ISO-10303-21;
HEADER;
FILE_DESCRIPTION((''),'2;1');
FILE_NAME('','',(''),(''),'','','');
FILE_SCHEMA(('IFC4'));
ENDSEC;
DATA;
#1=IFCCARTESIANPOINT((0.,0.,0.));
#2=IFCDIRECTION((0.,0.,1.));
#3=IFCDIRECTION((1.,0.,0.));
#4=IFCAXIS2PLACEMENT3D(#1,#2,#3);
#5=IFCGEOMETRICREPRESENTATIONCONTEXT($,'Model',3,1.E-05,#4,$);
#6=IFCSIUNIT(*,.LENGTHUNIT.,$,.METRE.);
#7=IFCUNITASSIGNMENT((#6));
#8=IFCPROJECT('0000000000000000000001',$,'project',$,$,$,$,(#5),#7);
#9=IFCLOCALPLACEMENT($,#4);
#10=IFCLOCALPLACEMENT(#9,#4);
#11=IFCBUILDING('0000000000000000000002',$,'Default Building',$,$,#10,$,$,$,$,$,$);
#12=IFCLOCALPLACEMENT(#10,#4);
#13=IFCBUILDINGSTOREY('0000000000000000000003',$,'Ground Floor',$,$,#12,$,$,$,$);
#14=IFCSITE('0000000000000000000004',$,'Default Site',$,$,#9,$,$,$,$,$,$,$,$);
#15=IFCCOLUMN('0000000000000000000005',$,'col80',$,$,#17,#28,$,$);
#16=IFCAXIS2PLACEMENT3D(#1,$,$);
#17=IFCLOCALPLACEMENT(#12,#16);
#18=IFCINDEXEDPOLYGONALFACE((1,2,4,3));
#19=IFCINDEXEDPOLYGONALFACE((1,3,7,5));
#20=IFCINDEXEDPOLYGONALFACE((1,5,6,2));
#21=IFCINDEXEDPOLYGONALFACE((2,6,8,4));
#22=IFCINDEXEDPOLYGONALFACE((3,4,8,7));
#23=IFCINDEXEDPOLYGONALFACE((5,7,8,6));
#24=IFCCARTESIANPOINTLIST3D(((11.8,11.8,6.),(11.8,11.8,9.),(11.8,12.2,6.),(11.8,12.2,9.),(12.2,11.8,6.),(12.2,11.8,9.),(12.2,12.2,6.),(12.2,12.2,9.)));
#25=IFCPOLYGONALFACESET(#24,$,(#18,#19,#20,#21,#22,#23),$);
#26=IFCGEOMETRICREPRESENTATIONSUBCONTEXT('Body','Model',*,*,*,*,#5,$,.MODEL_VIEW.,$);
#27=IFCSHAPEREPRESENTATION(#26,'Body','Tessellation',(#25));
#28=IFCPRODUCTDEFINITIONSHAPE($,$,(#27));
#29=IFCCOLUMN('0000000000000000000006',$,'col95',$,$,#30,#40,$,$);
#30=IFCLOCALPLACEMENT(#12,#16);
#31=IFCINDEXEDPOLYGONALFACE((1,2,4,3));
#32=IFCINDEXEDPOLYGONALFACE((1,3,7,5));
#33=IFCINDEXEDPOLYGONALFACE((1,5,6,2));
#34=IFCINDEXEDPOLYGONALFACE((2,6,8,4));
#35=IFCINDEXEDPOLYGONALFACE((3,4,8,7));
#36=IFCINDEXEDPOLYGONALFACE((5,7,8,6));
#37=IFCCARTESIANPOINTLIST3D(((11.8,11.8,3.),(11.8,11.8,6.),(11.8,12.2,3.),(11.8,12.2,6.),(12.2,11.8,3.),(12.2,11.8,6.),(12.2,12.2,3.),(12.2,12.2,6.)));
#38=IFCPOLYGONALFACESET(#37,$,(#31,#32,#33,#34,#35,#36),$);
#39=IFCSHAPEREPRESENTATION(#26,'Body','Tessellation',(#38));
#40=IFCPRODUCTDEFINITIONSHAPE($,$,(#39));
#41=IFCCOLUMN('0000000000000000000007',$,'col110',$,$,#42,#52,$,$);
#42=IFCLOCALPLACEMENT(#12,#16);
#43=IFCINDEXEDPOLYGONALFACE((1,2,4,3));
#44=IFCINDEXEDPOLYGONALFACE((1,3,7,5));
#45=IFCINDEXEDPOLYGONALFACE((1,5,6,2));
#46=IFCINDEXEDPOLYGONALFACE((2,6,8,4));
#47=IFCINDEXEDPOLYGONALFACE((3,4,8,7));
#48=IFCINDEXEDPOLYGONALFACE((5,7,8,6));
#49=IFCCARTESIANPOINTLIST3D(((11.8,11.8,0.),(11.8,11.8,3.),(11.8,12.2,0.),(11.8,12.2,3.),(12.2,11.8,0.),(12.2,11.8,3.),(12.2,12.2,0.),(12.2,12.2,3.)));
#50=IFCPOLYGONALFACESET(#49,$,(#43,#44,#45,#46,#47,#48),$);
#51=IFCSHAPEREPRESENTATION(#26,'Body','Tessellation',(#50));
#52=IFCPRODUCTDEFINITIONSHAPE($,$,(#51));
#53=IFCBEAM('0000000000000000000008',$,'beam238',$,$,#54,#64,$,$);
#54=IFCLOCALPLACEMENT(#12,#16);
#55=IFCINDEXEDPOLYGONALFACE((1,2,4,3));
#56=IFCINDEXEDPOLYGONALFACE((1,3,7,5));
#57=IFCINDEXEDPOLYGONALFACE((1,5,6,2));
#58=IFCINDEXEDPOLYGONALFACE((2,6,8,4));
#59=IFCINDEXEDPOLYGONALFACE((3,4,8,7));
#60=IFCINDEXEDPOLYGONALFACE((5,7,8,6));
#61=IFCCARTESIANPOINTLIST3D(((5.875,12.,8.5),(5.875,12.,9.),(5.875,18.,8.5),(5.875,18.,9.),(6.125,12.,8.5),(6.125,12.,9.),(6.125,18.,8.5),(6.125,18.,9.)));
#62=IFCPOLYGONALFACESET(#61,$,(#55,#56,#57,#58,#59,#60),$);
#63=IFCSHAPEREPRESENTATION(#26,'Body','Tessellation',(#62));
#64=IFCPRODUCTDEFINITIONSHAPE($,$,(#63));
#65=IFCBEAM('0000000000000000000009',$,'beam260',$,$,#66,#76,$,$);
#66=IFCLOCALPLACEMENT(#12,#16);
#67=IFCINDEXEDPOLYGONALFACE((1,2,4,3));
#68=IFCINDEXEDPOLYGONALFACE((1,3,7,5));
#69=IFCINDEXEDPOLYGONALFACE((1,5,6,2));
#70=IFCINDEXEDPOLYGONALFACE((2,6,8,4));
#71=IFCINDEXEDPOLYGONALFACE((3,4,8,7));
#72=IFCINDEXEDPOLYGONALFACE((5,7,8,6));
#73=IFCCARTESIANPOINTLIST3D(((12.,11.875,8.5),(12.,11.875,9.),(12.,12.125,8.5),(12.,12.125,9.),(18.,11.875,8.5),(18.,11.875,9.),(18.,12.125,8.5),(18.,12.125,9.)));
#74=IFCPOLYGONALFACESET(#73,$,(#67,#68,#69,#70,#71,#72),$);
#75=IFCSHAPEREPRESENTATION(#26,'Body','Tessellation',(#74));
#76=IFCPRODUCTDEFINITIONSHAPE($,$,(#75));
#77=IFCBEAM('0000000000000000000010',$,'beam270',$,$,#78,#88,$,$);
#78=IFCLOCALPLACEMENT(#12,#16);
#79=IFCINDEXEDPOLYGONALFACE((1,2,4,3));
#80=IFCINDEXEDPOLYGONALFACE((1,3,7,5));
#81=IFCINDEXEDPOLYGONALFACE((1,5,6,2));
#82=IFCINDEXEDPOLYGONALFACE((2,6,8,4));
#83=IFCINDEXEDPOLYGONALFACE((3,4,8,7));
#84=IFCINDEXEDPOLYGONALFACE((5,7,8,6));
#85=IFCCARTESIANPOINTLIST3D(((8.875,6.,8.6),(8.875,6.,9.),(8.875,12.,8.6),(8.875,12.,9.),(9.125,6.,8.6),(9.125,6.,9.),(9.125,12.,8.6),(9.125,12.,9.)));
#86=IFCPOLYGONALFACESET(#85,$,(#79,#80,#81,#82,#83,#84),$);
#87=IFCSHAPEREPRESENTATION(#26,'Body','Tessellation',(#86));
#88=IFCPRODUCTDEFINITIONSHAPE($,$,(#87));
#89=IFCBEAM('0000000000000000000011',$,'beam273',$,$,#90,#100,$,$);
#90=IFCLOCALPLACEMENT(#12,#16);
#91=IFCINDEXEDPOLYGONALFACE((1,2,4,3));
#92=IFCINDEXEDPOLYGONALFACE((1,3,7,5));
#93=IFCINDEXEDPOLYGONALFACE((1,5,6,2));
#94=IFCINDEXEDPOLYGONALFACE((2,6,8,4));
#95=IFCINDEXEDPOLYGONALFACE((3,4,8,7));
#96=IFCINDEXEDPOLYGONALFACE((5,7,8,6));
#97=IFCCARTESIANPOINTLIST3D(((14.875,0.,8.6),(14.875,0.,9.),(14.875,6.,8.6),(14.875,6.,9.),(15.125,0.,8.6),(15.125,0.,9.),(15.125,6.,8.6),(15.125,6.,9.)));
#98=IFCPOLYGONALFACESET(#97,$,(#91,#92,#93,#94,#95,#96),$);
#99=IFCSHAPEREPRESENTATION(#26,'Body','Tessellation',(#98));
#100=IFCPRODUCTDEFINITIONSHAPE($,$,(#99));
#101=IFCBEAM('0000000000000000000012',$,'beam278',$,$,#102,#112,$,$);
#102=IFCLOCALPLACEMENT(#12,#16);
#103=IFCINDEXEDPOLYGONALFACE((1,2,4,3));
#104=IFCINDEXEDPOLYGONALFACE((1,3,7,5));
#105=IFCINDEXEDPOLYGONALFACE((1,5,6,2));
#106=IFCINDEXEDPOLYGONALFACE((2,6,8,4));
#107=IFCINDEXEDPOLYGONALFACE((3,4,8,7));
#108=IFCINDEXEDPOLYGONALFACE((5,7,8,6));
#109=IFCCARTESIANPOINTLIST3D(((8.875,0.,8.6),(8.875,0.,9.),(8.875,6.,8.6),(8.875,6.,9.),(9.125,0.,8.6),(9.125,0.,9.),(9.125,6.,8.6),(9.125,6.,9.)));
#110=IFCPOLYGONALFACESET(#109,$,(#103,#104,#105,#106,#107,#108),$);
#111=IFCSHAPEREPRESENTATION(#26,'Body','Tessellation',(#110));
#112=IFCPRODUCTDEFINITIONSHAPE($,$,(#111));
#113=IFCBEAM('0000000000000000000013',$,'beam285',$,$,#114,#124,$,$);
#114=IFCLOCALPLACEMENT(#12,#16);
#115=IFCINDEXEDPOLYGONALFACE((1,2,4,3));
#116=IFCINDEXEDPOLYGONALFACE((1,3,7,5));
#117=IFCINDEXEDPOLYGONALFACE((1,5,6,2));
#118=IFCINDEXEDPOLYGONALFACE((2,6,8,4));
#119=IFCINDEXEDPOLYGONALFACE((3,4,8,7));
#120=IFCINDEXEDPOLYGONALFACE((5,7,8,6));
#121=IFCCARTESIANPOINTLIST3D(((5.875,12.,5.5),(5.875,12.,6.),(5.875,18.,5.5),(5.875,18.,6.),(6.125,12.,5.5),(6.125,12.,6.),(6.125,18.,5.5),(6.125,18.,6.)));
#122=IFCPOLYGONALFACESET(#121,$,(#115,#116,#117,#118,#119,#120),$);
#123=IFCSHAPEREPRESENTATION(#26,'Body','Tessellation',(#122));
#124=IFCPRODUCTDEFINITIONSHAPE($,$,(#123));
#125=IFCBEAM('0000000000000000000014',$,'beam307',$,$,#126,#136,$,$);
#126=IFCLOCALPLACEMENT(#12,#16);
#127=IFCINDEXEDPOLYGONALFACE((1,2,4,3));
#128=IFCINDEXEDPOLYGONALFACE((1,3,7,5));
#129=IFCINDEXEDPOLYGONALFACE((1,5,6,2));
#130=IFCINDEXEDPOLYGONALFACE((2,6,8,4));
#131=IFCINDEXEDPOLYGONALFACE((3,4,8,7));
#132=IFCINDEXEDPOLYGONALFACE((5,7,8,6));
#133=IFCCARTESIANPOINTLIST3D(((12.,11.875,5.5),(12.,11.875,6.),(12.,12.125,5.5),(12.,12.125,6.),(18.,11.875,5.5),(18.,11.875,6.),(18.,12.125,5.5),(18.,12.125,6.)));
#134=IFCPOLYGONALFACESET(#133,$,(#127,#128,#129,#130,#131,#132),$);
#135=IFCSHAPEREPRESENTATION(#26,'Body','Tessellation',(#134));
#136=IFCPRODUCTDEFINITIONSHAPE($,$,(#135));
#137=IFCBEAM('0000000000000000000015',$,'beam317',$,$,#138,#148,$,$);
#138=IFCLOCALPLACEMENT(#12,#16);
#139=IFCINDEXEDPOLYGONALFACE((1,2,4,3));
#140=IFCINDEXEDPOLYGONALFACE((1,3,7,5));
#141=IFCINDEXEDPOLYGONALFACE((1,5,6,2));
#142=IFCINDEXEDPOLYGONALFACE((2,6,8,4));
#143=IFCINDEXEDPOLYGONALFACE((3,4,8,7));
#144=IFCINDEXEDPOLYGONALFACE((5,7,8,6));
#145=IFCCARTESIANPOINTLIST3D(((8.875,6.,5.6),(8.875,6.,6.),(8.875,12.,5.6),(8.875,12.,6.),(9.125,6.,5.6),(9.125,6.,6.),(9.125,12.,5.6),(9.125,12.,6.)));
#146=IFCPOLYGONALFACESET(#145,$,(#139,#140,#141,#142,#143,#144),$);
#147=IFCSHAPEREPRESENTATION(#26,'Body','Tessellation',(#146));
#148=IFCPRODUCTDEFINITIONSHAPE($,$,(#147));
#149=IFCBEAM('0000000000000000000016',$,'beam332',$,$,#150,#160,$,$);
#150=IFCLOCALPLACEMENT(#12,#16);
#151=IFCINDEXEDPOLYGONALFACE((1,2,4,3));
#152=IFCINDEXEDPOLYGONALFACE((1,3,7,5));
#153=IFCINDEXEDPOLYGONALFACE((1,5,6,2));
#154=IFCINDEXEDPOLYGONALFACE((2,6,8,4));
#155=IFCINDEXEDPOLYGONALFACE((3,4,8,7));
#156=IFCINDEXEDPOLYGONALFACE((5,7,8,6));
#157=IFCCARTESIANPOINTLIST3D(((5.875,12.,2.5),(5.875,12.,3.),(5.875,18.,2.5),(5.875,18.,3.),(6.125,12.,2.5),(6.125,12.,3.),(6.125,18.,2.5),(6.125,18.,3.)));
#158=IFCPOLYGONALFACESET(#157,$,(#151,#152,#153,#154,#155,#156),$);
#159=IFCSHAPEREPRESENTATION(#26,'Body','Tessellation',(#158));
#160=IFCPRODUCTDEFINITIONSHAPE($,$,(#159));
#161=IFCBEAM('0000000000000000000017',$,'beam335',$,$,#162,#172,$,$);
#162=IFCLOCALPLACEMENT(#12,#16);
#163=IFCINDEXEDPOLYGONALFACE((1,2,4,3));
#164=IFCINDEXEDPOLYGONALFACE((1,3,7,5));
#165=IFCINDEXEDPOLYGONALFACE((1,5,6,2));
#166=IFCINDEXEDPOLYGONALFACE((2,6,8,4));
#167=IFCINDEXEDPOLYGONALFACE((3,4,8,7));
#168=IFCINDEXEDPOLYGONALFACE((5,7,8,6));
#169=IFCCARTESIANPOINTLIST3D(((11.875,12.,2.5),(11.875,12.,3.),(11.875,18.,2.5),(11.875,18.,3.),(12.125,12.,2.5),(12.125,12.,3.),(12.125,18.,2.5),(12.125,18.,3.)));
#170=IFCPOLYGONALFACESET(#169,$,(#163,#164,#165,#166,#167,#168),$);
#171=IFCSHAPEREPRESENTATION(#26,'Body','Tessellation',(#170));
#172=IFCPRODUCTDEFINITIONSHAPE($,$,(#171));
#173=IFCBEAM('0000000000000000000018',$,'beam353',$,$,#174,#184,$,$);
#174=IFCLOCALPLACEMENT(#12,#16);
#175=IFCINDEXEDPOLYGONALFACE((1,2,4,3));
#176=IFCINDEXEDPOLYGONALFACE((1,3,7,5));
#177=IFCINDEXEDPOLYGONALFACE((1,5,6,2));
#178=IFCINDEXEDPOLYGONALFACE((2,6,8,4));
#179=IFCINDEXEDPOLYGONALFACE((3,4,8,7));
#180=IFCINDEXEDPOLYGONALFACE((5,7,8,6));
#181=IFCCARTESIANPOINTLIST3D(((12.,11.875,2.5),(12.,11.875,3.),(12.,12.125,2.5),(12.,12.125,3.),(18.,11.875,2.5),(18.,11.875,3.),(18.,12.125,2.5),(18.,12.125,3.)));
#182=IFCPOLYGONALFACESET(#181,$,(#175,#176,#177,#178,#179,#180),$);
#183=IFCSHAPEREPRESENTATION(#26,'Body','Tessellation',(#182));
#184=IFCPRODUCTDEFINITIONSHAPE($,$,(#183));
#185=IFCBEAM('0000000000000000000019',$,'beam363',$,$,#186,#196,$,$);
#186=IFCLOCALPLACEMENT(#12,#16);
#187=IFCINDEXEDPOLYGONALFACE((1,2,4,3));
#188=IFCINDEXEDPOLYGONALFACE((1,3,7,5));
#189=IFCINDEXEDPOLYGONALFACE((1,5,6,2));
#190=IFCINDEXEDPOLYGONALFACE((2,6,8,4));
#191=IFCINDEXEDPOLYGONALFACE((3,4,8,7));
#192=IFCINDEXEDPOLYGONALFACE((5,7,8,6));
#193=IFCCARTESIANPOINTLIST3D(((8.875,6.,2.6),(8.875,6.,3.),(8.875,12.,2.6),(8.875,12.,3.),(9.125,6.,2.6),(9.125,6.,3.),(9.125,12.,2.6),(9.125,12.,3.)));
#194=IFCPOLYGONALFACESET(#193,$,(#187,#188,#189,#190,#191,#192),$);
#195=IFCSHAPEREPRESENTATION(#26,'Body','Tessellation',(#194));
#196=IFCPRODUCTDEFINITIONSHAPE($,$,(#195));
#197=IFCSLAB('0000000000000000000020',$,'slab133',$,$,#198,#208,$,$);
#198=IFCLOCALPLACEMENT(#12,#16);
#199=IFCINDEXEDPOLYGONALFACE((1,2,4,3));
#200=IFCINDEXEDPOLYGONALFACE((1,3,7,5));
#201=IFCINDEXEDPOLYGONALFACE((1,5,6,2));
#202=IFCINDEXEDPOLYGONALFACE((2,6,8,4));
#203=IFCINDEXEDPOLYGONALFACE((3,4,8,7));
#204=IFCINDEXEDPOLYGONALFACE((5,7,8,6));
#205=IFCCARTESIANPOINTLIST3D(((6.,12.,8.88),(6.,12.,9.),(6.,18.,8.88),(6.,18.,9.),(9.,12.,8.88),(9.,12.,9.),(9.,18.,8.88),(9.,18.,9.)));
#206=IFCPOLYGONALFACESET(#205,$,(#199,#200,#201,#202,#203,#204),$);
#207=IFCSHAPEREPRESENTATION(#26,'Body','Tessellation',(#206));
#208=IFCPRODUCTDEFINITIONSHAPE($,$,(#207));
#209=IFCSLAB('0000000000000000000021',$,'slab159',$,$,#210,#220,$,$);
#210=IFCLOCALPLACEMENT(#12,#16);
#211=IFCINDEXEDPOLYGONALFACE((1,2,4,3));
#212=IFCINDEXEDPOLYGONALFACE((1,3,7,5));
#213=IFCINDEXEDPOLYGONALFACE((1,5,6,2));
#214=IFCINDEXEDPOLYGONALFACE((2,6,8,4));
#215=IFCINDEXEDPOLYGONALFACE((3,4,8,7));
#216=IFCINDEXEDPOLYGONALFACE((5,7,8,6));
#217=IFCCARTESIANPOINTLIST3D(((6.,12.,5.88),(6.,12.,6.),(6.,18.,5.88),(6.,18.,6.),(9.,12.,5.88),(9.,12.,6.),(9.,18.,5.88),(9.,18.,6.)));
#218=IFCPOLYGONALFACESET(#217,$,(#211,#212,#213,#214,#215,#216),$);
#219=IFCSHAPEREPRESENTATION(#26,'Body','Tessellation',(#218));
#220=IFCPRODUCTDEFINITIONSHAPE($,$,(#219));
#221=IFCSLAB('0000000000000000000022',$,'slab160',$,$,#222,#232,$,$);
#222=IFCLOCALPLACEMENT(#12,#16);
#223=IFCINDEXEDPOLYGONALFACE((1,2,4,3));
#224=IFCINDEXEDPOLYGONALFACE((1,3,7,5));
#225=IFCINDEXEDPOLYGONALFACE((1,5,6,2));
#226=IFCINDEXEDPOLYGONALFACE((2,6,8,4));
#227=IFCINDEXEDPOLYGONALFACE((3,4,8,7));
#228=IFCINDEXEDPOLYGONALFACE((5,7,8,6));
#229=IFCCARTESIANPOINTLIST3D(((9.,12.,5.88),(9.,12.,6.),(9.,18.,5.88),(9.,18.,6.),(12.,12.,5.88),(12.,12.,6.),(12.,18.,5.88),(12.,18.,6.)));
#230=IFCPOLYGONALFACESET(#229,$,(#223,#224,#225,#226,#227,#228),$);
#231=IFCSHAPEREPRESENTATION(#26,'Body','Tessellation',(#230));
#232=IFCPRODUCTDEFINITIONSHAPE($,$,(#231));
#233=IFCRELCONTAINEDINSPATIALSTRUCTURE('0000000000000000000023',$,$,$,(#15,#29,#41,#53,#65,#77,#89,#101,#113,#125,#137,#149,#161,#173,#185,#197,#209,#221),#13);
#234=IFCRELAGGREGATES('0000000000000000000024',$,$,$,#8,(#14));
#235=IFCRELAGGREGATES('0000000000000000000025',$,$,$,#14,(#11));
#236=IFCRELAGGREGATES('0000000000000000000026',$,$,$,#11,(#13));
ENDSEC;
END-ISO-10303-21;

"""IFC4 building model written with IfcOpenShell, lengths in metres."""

from ifc_helpers import new_model, si_unit, frame, origin_with_axes, place, context, subcontext, project, spatial, indexed_curve, outline, extrude, element, save


model = new_model("IFC4")

# Units and contexts
model_context = context("Model", 3, precision=1e-05, world=origin_with_axes())
body_context = subcontext(model_context, "Body", "Model", "MODEL_VIEW")
ifc_project = project(units=[si_unit("LENGTHUNIT", "METRE")], contexts=[model_context])

# Site, building, storey
site_placement = place(None, origin_with_axes())
site = spatial("IfcSite", under=ifc_project, at=site_placement, Name="Default Site")
building_placement = place(site_placement, origin_with_axes())
building = spatial("IfcBuilding", under=site, at=building_placement, Name="Default Building")
storey_placement = place(building_placement, origin_with_axes())
storey = spatial("IfcBuildingStorey", under=building, at=storey_placement, Name="Ground Floor")

# Columns
for number, where, z_axis, x_axis, name in (
    (1, (11.8, 11.8, 6.0), (0.0, 0.0, 1.0), (1.0, 0.0, 0.0), "col80"),
    (2, (11.8, 11.8, 3.0), (0.0, 0.0, 1.0), (1.0, 0.0, 0.0), "col95"),
    (3, (11.8, 11.8, 0.0), (0.0, 0.0, 1.0), (1.0, 0.0, 0.0), "col110"),
):
    element("IfcColumn", number, at=place(storey_placement, frame(where, z_axis=z_axis, x_axis=x_axis)), inside=storey, Name=name, context=body_context, shape_type="SweptSolid", body=[
        extrude(outline(indexed_curve([(0.0, 0.0), (0.0, 0.4), (0.4, 0.4), (0.4, 0.0), (0.0, 0.0)], self_intersect=False)), origin_with_axes(), (0.0, 0.0, 1.0), 3.0),
    ])

# Beams
for number, where, z_axis, x_axis, name in (
    (4, (6.125, 12.0, 8.5), (0.0, 0.0, 1.0), (0.0, 1.0, 0.0), "beam238"),
    (5, (12.0, 11.875, 8.5), (0.0, 0.0, 1.0), (1.0, 0.0, 0.0), "beam260"),
):
    element("IfcBeam", number, at=place(storey_placement, frame(where, z_axis=z_axis, x_axis=x_axis)), inside=storey, Name=name, context=body_context, shape_type="SweptSolid", body=[
        extrude(outline(indexed_curve([(0.0, 0.0), (0.0, 0.25), (6.0, 0.25), (6.0, 0.0), (0.0, 0.0)], self_intersect=False)), origin_with_axes(), (0.0, 0.0, 1.0), 0.5),
    ])
for number, where, z_axis, x_axis, name in (
    (6, (8.875, 12.0, 8.6), (0.0, 0.0, 1.0), (0.0, -1.0, 0.0), "beam270"),
    (7, (14.875, 6.0, 8.6), (0.0, 0.0, 1.0), (0.0, -1.0, 0.0), "beam273"),
    (8, (8.875, 6.0, 8.6), (0.0, 0.0, 1.0), (0.0, -1.0, 0.0), "beam278"),
):
    element("IfcBeam", number, at=place(storey_placement, frame(where, z_axis=z_axis, x_axis=x_axis)), inside=storey, Name=name, context=body_context, shape_type="SweptSolid", body=[
        extrude(outline(indexed_curve([(0.0, 0.0), (0.0, 0.25), (6.0, 0.25), (6.0, 0.0), (0.0, 0.0)], self_intersect=False)), origin_with_axes(), (0.0, 0.0, 1.0), 0.4),
    ])
for number, where, z_axis, x_axis, name in (
    (9, (6.125, 12.0, 5.5), (0.0, 0.0, 1.0), (0.0, 1.0, 0.0), "beam285"),
    (10, (12.0, 11.875, 5.5), (0.0, 0.0, 1.0), (1.0, 0.0, 0.0), "beam307"),
):
    element("IfcBeam", number, at=place(storey_placement, frame(where, z_axis=z_axis, x_axis=x_axis)), inside=storey, Name=name, context=body_context, shape_type="SweptSolid", body=[
        extrude(outline(indexed_curve([(0.0, 0.0), (0.0, 0.25), (6.0, 0.25), (6.0, 0.0), (0.0, 0.0)], self_intersect=False)), origin_with_axes(), (0.0, 0.0, 1.0), 0.5),
    ])
beam_1_placement = place(storey_placement, frame((8.875, 12.0, 5.6), z_axis=(0.0, 0.0, 1.0), x_axis=(0.0, -1.0, 0.0)))
element("IfcBeam", 11, at=beam_1_placement, inside=storey, Name="beam317", context=body_context, shape_type="SweptSolid", body=[
    extrude(outline(indexed_curve([(0.0, 0.0), (0.0, 0.25), (6.0, 0.25), (6.0, 0.0), (0.0, 0.0)], self_intersect=False)), origin_with_axes(), (0.0, 0.0, 1.0), 0.4),
])
for number, where, z_axis, x_axis, name in (
    (12, (6.125, 12.0, 2.5), (0.0, 0.0, 1.0), (0.0, 1.0, 0.0), "beam332"),
    (13, (12.125, 12.0, 2.5), (0.0, 0.0, 1.0), (0.0, 1.0, 0.0), "beam335"),
    (14, (12.0, 11.875, 2.5), (0.0, 0.0, 1.0), (1.0, 0.0, 0.0), "beam353"),
):
    element("IfcBeam", number, at=place(storey_placement, frame(where, z_axis=z_axis, x_axis=x_axis)), inside=storey, Name=name, context=body_context, shape_type="SweptSolid", body=[
        extrude(outline(indexed_curve([(0.0, 0.0), (0.0, 0.25), (6.0, 0.25), (6.0, 0.0), (0.0, 0.0)], self_intersect=False)), origin_with_axes(), (0.0, 0.0, 1.0), 0.5),
    ])
beam_2_placement = place(storey_placement, frame((8.875, 12.0, 2.6), z_axis=(0.0, 0.0, 1.0), x_axis=(0.0, -1.0, 0.0)))
element("IfcBeam", 15, at=beam_2_placement, inside=storey, Name="beam363", context=body_context, shape_type="SweptSolid", body=[
    extrude(outline(indexed_curve([(0.0, 0.0), (0.0, 0.25), (6.0, 0.25), (6.0, 0.0), (0.0, 0.0)], self_intersect=False)), origin_with_axes(), (0.0, 0.0, 1.0), 0.4),
])

# Slabs
for number, where, z_axis, x_axis, name in (
    (16, (6.0, 12.0, 8.88), (0.0, 0.0, 1.0), (1.0, 0.0, 0.0), "slab133"),
    (17, (6.0, 12.0, 5.88), (0.0, 0.0, 1.0), (1.0, 0.0, 0.0), "slab159"),
    (18, (9.0, 12.0, 5.88), (0.0, 0.0, 1.0), (1.0, 0.0, 0.0), "slab160"),
):
    element("IfcSlab", number, at=place(storey_placement, frame(where, z_axis=z_axis, x_axis=x_axis)), inside=storey, Name=name, context=body_context, shape_type="SweptSolid", body=[
        extrude(outline(indexed_curve([(0.0, 0.0), (0.0, 6.0), (3.0, 6.0), (3.0, 0.0), (0.0, 0.0)], self_intersect=False)), origin_with_axes(), (0.0, 0.0, 1.0), 0.12),
    ])

save(model, "model.ifc")
